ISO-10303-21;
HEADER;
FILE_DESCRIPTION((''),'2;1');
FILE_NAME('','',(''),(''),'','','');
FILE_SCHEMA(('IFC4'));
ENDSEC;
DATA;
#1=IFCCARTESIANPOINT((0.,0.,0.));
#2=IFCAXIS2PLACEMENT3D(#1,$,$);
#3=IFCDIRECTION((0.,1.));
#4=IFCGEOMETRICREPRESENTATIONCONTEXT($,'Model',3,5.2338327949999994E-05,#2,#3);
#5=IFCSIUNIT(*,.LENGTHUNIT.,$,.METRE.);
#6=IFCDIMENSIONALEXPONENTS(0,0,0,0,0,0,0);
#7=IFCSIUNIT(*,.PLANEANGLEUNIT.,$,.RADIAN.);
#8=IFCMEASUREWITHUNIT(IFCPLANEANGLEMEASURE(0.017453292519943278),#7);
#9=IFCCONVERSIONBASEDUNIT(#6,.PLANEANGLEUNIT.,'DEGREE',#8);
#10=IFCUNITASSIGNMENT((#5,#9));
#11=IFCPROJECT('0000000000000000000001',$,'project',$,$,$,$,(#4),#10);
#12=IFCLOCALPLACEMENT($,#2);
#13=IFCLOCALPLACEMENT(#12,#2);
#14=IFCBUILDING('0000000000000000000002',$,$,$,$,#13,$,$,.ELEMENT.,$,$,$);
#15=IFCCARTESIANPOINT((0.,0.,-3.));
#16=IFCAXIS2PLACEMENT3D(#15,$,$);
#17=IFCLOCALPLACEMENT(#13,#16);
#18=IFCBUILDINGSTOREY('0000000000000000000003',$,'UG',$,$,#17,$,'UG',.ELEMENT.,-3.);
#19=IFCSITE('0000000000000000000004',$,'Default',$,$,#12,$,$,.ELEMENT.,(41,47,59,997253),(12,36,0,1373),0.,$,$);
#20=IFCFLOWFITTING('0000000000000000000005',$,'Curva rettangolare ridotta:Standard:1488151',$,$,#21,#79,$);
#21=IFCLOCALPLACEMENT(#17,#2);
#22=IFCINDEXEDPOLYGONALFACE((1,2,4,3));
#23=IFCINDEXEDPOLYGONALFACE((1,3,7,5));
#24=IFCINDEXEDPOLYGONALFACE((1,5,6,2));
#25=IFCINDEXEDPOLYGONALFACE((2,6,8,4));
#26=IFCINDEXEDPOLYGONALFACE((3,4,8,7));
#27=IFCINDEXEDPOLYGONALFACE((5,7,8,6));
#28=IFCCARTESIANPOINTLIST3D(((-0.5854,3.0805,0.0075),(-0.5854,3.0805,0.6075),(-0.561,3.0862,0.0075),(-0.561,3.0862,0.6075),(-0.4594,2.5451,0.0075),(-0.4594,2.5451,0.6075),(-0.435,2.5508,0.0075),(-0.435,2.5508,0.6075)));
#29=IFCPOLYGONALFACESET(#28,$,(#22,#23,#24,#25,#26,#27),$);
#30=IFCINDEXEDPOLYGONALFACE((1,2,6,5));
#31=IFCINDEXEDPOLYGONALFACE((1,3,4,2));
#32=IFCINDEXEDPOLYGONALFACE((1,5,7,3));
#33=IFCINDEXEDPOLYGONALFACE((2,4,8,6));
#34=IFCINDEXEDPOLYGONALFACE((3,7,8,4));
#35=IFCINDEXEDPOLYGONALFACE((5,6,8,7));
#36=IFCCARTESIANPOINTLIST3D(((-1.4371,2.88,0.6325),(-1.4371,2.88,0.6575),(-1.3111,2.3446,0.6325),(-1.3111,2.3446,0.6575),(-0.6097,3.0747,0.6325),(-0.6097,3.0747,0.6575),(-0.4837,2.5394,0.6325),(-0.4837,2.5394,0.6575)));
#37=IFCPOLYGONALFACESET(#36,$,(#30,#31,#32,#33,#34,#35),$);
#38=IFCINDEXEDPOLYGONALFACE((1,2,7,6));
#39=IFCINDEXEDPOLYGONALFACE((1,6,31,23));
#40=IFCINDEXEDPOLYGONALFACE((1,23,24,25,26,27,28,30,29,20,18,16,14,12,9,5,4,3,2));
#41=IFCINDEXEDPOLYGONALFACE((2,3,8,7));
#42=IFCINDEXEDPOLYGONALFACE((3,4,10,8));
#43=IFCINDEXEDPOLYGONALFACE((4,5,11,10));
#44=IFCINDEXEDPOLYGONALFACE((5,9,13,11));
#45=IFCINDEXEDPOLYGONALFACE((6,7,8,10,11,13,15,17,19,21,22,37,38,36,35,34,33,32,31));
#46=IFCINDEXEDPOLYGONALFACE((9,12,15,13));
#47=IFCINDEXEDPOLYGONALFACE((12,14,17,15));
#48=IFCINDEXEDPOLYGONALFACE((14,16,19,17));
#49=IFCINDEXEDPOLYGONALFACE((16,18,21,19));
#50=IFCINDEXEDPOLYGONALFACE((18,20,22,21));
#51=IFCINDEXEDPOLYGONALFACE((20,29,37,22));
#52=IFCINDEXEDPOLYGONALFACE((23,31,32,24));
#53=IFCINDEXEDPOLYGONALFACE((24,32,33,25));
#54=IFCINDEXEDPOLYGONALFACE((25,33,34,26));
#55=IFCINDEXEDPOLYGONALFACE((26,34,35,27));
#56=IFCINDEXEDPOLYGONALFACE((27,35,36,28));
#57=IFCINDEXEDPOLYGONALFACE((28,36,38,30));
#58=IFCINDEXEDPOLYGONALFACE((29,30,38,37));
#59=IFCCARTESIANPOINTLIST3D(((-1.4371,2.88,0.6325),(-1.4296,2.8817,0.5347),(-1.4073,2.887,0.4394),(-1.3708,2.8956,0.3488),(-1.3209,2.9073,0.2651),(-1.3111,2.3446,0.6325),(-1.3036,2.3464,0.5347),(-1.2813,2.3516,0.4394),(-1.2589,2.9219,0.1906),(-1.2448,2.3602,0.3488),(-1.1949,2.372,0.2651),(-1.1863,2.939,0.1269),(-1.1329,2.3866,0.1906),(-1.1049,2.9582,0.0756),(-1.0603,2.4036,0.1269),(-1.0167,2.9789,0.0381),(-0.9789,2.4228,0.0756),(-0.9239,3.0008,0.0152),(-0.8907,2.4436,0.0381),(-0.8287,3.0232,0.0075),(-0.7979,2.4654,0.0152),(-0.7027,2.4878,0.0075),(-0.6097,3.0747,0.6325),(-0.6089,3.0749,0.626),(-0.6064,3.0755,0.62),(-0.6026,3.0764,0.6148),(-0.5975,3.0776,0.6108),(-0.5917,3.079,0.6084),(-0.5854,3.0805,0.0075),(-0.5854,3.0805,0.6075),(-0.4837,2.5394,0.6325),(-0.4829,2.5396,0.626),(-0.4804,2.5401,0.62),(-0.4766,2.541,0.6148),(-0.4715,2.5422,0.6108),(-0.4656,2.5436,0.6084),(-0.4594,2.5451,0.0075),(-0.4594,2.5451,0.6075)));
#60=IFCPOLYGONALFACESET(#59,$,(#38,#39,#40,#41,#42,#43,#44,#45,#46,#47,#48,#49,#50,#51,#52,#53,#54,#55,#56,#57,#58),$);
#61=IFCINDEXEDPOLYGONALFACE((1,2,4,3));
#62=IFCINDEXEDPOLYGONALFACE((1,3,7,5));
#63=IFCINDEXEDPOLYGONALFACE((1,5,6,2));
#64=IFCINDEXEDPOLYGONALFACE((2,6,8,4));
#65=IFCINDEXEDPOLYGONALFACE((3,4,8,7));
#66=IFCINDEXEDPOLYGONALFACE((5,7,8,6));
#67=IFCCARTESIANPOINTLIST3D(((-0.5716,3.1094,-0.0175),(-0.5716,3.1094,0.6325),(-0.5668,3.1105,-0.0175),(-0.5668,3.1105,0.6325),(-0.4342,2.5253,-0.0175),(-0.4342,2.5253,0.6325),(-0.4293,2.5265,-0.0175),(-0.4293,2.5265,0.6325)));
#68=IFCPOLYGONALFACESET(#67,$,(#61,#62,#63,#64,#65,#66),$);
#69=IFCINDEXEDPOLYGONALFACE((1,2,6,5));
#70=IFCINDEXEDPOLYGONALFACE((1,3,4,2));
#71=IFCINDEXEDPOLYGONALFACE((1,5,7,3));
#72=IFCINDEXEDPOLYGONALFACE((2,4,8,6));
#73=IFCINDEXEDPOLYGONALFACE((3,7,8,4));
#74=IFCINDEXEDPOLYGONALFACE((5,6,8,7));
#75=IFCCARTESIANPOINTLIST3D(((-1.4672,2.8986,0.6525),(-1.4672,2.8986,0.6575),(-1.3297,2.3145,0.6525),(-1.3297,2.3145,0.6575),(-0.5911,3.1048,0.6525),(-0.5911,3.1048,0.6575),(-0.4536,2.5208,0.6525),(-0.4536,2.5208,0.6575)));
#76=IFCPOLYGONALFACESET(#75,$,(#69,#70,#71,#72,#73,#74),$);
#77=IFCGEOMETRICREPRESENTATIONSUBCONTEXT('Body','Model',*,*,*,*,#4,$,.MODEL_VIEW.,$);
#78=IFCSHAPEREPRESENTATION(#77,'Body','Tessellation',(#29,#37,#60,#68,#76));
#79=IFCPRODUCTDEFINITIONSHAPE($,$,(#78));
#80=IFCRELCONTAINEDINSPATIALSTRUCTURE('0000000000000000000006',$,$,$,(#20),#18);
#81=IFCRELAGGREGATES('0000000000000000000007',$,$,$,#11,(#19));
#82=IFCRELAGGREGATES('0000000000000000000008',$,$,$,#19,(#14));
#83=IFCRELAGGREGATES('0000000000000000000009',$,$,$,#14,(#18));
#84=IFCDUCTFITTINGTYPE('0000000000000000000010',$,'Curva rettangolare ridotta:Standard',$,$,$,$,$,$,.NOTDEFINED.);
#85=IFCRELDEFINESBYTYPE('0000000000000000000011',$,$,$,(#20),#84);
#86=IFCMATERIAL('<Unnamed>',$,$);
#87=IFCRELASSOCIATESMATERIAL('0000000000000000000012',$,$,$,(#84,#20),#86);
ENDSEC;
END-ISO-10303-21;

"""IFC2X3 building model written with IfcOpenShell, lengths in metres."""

from ifc_helpers import new_model, entity, si_unit, converted_unit, direction, frame, frame_2d, origin, origin_2d_with_axis, place, context, subcontext, project, spatial, polyline, circle_curve, parameter, trimmed, segment, composite_curve, rectangle, outline, extrude, source, transform, mapped, material, type_object, type_shapes, element, save


model = new_model("IFC2X3")

# Units and contexts
model_context = context("Model", 3, precision=5.2338327949999994e-05, world=origin(), true_north=direction((0.0, 1.0)))
body_context = subcontext(model_context, "Body", "Model", "MODEL_VIEW")
ifc_project = project(units=[si_unit("LENGTHUNIT", "METRE"), converted_unit("PLANEANGLEUNIT", "DEGREE", entity("IfcPlaneAngleMeasure", 0.017453292519943278), si_unit("PLANEANGLEUNIT", "RADIAN"), dimensions=[0, 0, 0, 0, 0, 0, 0])], contexts=[model_context])

# Site, building, storey
site_placement = place(None, origin())
site = spatial("IfcSite", under=ifc_project, at=site_placement, Name="Default", CompositionType="ELEMENT", RefLatitude=(41, 47, 59, 997253), RefLongitude=(12, 36, 0, 1373), RefElevation=0.0)
building_placement = place(site_placement, origin())
building = spatial("IfcBuilding", under=site, at=building_placement, CompositionType="ELEMENT")
storey_placement = place(building_placement, frame((0.0, 0.0, -3.0)))
storey = spatial("IfcBuildingStorey", under=building, at=storey_placement, Name="UG", LongName="UG", CompositionType="ELEMENT", Elevation=-3.0)

# Shared definitions
ifc_material = material(Name="<Unnamed>")

# Flow fitting
duct_fitting_type_1 = type_object("IfcDuctFittingType", Name="Curva rettangolare ridotta:Standard", PredefinedType="NOTDEFINED", material=ifc_material)
shared_shape_1 = source(origin(), body_context, "Body", "SweptSolid", [
    extrude(rectangle(XDim=0.025, YDim=0.6, at=origin_2d_with_axis()), frame((-0.4625, 0.0, -0.275), z_axis=(0.0, 0.0, 1.0), x_axis=(-1.0, 0.0, 0.0)), (0.0, 0.0, 1.0), 0.55),
    extrude(rectangle(XDim=0.025, YDim=0.85, at=origin_2d_with_axis()), frame((0.0, 0.3375, -0.275), z_axis=(0.0, 0.0, 1.0), x_axis=(0.0, 1.0, 0.0)), (0.0, 0.0, 1.0), 0.55),
    extrude(outline(composite_curve([segment(polyline([(-0.23, -0.37), (0.02, -0.37)]), True, "CONTINUOUS"), segment(trimmed(circle_curve(frame_2d((0.02, 0.255), x_axis=(1.0, 0.0)), 0.625), [parameter(270.0)], [parameter(360.0)], True, "PARAMETER"), True, "CONTINUOUS"), segment(polyline([(0.645, 0.255), (-0.205, 0.255)]), True, "CONTINUOUS"), segment(trimmed(circle_curve(frame_2d((-0.23, 0.255), x_axis=(1.0, 0.0)), 0.025), [parameter(270.0)], [parameter(0.0)], True, "PARAMETER"), False, "CONTINUOUS"), segment(polyline([(-0.23, 0.23), (-0.23, -0.37)]), True, "CONTINUOUS")], self_intersect=False)), frame((-0.22, 0.07, -0.275)), (0.0, 0.0, 1.0), 0.55),
    extrude(rectangle(XDim=0.005, YDim=0.65, at=origin_2d_with_axis()), frame((-0.4725, 0.0, -0.3)), (0.0, 0.0, 1.0), 0.6),
    extrude(rectangle(XDim=0.005, YDim=0.9, at=origin_2d_with_axis()), frame((0.0, 0.3475, -0.3), z_axis=(0.0, 0.0, 1.0), x_axis=(0.0, 1.0, 0.0)), (0.0, 0.0, 1.0), 0.6),
])
type_shapes(duct_fitting_type_1, [shared_shape_1])
flow_fitting_1_placement = place(storey_placement, frame((-0.9604, 2.7097, 0.3075), z_axis=(-0.229116, 0.973399, 0.0), x_axis=(-0.973399, -0.229116, 0.0)))
element("IfcFlowFitting", 1, at=flow_fitting_1_placement, inside=storey, type_object=duct_fitting_type_1, material=ifc_material, Name="Curva rettangolare ridotta:Standard:1488151", context=body_context, shape_type="MappedRepresentation", body=[
    mapped(shared_shape_1, transform((0.0, 0.0, 0.0), scale=1.0)),
])

save(model, "model.ifc")
